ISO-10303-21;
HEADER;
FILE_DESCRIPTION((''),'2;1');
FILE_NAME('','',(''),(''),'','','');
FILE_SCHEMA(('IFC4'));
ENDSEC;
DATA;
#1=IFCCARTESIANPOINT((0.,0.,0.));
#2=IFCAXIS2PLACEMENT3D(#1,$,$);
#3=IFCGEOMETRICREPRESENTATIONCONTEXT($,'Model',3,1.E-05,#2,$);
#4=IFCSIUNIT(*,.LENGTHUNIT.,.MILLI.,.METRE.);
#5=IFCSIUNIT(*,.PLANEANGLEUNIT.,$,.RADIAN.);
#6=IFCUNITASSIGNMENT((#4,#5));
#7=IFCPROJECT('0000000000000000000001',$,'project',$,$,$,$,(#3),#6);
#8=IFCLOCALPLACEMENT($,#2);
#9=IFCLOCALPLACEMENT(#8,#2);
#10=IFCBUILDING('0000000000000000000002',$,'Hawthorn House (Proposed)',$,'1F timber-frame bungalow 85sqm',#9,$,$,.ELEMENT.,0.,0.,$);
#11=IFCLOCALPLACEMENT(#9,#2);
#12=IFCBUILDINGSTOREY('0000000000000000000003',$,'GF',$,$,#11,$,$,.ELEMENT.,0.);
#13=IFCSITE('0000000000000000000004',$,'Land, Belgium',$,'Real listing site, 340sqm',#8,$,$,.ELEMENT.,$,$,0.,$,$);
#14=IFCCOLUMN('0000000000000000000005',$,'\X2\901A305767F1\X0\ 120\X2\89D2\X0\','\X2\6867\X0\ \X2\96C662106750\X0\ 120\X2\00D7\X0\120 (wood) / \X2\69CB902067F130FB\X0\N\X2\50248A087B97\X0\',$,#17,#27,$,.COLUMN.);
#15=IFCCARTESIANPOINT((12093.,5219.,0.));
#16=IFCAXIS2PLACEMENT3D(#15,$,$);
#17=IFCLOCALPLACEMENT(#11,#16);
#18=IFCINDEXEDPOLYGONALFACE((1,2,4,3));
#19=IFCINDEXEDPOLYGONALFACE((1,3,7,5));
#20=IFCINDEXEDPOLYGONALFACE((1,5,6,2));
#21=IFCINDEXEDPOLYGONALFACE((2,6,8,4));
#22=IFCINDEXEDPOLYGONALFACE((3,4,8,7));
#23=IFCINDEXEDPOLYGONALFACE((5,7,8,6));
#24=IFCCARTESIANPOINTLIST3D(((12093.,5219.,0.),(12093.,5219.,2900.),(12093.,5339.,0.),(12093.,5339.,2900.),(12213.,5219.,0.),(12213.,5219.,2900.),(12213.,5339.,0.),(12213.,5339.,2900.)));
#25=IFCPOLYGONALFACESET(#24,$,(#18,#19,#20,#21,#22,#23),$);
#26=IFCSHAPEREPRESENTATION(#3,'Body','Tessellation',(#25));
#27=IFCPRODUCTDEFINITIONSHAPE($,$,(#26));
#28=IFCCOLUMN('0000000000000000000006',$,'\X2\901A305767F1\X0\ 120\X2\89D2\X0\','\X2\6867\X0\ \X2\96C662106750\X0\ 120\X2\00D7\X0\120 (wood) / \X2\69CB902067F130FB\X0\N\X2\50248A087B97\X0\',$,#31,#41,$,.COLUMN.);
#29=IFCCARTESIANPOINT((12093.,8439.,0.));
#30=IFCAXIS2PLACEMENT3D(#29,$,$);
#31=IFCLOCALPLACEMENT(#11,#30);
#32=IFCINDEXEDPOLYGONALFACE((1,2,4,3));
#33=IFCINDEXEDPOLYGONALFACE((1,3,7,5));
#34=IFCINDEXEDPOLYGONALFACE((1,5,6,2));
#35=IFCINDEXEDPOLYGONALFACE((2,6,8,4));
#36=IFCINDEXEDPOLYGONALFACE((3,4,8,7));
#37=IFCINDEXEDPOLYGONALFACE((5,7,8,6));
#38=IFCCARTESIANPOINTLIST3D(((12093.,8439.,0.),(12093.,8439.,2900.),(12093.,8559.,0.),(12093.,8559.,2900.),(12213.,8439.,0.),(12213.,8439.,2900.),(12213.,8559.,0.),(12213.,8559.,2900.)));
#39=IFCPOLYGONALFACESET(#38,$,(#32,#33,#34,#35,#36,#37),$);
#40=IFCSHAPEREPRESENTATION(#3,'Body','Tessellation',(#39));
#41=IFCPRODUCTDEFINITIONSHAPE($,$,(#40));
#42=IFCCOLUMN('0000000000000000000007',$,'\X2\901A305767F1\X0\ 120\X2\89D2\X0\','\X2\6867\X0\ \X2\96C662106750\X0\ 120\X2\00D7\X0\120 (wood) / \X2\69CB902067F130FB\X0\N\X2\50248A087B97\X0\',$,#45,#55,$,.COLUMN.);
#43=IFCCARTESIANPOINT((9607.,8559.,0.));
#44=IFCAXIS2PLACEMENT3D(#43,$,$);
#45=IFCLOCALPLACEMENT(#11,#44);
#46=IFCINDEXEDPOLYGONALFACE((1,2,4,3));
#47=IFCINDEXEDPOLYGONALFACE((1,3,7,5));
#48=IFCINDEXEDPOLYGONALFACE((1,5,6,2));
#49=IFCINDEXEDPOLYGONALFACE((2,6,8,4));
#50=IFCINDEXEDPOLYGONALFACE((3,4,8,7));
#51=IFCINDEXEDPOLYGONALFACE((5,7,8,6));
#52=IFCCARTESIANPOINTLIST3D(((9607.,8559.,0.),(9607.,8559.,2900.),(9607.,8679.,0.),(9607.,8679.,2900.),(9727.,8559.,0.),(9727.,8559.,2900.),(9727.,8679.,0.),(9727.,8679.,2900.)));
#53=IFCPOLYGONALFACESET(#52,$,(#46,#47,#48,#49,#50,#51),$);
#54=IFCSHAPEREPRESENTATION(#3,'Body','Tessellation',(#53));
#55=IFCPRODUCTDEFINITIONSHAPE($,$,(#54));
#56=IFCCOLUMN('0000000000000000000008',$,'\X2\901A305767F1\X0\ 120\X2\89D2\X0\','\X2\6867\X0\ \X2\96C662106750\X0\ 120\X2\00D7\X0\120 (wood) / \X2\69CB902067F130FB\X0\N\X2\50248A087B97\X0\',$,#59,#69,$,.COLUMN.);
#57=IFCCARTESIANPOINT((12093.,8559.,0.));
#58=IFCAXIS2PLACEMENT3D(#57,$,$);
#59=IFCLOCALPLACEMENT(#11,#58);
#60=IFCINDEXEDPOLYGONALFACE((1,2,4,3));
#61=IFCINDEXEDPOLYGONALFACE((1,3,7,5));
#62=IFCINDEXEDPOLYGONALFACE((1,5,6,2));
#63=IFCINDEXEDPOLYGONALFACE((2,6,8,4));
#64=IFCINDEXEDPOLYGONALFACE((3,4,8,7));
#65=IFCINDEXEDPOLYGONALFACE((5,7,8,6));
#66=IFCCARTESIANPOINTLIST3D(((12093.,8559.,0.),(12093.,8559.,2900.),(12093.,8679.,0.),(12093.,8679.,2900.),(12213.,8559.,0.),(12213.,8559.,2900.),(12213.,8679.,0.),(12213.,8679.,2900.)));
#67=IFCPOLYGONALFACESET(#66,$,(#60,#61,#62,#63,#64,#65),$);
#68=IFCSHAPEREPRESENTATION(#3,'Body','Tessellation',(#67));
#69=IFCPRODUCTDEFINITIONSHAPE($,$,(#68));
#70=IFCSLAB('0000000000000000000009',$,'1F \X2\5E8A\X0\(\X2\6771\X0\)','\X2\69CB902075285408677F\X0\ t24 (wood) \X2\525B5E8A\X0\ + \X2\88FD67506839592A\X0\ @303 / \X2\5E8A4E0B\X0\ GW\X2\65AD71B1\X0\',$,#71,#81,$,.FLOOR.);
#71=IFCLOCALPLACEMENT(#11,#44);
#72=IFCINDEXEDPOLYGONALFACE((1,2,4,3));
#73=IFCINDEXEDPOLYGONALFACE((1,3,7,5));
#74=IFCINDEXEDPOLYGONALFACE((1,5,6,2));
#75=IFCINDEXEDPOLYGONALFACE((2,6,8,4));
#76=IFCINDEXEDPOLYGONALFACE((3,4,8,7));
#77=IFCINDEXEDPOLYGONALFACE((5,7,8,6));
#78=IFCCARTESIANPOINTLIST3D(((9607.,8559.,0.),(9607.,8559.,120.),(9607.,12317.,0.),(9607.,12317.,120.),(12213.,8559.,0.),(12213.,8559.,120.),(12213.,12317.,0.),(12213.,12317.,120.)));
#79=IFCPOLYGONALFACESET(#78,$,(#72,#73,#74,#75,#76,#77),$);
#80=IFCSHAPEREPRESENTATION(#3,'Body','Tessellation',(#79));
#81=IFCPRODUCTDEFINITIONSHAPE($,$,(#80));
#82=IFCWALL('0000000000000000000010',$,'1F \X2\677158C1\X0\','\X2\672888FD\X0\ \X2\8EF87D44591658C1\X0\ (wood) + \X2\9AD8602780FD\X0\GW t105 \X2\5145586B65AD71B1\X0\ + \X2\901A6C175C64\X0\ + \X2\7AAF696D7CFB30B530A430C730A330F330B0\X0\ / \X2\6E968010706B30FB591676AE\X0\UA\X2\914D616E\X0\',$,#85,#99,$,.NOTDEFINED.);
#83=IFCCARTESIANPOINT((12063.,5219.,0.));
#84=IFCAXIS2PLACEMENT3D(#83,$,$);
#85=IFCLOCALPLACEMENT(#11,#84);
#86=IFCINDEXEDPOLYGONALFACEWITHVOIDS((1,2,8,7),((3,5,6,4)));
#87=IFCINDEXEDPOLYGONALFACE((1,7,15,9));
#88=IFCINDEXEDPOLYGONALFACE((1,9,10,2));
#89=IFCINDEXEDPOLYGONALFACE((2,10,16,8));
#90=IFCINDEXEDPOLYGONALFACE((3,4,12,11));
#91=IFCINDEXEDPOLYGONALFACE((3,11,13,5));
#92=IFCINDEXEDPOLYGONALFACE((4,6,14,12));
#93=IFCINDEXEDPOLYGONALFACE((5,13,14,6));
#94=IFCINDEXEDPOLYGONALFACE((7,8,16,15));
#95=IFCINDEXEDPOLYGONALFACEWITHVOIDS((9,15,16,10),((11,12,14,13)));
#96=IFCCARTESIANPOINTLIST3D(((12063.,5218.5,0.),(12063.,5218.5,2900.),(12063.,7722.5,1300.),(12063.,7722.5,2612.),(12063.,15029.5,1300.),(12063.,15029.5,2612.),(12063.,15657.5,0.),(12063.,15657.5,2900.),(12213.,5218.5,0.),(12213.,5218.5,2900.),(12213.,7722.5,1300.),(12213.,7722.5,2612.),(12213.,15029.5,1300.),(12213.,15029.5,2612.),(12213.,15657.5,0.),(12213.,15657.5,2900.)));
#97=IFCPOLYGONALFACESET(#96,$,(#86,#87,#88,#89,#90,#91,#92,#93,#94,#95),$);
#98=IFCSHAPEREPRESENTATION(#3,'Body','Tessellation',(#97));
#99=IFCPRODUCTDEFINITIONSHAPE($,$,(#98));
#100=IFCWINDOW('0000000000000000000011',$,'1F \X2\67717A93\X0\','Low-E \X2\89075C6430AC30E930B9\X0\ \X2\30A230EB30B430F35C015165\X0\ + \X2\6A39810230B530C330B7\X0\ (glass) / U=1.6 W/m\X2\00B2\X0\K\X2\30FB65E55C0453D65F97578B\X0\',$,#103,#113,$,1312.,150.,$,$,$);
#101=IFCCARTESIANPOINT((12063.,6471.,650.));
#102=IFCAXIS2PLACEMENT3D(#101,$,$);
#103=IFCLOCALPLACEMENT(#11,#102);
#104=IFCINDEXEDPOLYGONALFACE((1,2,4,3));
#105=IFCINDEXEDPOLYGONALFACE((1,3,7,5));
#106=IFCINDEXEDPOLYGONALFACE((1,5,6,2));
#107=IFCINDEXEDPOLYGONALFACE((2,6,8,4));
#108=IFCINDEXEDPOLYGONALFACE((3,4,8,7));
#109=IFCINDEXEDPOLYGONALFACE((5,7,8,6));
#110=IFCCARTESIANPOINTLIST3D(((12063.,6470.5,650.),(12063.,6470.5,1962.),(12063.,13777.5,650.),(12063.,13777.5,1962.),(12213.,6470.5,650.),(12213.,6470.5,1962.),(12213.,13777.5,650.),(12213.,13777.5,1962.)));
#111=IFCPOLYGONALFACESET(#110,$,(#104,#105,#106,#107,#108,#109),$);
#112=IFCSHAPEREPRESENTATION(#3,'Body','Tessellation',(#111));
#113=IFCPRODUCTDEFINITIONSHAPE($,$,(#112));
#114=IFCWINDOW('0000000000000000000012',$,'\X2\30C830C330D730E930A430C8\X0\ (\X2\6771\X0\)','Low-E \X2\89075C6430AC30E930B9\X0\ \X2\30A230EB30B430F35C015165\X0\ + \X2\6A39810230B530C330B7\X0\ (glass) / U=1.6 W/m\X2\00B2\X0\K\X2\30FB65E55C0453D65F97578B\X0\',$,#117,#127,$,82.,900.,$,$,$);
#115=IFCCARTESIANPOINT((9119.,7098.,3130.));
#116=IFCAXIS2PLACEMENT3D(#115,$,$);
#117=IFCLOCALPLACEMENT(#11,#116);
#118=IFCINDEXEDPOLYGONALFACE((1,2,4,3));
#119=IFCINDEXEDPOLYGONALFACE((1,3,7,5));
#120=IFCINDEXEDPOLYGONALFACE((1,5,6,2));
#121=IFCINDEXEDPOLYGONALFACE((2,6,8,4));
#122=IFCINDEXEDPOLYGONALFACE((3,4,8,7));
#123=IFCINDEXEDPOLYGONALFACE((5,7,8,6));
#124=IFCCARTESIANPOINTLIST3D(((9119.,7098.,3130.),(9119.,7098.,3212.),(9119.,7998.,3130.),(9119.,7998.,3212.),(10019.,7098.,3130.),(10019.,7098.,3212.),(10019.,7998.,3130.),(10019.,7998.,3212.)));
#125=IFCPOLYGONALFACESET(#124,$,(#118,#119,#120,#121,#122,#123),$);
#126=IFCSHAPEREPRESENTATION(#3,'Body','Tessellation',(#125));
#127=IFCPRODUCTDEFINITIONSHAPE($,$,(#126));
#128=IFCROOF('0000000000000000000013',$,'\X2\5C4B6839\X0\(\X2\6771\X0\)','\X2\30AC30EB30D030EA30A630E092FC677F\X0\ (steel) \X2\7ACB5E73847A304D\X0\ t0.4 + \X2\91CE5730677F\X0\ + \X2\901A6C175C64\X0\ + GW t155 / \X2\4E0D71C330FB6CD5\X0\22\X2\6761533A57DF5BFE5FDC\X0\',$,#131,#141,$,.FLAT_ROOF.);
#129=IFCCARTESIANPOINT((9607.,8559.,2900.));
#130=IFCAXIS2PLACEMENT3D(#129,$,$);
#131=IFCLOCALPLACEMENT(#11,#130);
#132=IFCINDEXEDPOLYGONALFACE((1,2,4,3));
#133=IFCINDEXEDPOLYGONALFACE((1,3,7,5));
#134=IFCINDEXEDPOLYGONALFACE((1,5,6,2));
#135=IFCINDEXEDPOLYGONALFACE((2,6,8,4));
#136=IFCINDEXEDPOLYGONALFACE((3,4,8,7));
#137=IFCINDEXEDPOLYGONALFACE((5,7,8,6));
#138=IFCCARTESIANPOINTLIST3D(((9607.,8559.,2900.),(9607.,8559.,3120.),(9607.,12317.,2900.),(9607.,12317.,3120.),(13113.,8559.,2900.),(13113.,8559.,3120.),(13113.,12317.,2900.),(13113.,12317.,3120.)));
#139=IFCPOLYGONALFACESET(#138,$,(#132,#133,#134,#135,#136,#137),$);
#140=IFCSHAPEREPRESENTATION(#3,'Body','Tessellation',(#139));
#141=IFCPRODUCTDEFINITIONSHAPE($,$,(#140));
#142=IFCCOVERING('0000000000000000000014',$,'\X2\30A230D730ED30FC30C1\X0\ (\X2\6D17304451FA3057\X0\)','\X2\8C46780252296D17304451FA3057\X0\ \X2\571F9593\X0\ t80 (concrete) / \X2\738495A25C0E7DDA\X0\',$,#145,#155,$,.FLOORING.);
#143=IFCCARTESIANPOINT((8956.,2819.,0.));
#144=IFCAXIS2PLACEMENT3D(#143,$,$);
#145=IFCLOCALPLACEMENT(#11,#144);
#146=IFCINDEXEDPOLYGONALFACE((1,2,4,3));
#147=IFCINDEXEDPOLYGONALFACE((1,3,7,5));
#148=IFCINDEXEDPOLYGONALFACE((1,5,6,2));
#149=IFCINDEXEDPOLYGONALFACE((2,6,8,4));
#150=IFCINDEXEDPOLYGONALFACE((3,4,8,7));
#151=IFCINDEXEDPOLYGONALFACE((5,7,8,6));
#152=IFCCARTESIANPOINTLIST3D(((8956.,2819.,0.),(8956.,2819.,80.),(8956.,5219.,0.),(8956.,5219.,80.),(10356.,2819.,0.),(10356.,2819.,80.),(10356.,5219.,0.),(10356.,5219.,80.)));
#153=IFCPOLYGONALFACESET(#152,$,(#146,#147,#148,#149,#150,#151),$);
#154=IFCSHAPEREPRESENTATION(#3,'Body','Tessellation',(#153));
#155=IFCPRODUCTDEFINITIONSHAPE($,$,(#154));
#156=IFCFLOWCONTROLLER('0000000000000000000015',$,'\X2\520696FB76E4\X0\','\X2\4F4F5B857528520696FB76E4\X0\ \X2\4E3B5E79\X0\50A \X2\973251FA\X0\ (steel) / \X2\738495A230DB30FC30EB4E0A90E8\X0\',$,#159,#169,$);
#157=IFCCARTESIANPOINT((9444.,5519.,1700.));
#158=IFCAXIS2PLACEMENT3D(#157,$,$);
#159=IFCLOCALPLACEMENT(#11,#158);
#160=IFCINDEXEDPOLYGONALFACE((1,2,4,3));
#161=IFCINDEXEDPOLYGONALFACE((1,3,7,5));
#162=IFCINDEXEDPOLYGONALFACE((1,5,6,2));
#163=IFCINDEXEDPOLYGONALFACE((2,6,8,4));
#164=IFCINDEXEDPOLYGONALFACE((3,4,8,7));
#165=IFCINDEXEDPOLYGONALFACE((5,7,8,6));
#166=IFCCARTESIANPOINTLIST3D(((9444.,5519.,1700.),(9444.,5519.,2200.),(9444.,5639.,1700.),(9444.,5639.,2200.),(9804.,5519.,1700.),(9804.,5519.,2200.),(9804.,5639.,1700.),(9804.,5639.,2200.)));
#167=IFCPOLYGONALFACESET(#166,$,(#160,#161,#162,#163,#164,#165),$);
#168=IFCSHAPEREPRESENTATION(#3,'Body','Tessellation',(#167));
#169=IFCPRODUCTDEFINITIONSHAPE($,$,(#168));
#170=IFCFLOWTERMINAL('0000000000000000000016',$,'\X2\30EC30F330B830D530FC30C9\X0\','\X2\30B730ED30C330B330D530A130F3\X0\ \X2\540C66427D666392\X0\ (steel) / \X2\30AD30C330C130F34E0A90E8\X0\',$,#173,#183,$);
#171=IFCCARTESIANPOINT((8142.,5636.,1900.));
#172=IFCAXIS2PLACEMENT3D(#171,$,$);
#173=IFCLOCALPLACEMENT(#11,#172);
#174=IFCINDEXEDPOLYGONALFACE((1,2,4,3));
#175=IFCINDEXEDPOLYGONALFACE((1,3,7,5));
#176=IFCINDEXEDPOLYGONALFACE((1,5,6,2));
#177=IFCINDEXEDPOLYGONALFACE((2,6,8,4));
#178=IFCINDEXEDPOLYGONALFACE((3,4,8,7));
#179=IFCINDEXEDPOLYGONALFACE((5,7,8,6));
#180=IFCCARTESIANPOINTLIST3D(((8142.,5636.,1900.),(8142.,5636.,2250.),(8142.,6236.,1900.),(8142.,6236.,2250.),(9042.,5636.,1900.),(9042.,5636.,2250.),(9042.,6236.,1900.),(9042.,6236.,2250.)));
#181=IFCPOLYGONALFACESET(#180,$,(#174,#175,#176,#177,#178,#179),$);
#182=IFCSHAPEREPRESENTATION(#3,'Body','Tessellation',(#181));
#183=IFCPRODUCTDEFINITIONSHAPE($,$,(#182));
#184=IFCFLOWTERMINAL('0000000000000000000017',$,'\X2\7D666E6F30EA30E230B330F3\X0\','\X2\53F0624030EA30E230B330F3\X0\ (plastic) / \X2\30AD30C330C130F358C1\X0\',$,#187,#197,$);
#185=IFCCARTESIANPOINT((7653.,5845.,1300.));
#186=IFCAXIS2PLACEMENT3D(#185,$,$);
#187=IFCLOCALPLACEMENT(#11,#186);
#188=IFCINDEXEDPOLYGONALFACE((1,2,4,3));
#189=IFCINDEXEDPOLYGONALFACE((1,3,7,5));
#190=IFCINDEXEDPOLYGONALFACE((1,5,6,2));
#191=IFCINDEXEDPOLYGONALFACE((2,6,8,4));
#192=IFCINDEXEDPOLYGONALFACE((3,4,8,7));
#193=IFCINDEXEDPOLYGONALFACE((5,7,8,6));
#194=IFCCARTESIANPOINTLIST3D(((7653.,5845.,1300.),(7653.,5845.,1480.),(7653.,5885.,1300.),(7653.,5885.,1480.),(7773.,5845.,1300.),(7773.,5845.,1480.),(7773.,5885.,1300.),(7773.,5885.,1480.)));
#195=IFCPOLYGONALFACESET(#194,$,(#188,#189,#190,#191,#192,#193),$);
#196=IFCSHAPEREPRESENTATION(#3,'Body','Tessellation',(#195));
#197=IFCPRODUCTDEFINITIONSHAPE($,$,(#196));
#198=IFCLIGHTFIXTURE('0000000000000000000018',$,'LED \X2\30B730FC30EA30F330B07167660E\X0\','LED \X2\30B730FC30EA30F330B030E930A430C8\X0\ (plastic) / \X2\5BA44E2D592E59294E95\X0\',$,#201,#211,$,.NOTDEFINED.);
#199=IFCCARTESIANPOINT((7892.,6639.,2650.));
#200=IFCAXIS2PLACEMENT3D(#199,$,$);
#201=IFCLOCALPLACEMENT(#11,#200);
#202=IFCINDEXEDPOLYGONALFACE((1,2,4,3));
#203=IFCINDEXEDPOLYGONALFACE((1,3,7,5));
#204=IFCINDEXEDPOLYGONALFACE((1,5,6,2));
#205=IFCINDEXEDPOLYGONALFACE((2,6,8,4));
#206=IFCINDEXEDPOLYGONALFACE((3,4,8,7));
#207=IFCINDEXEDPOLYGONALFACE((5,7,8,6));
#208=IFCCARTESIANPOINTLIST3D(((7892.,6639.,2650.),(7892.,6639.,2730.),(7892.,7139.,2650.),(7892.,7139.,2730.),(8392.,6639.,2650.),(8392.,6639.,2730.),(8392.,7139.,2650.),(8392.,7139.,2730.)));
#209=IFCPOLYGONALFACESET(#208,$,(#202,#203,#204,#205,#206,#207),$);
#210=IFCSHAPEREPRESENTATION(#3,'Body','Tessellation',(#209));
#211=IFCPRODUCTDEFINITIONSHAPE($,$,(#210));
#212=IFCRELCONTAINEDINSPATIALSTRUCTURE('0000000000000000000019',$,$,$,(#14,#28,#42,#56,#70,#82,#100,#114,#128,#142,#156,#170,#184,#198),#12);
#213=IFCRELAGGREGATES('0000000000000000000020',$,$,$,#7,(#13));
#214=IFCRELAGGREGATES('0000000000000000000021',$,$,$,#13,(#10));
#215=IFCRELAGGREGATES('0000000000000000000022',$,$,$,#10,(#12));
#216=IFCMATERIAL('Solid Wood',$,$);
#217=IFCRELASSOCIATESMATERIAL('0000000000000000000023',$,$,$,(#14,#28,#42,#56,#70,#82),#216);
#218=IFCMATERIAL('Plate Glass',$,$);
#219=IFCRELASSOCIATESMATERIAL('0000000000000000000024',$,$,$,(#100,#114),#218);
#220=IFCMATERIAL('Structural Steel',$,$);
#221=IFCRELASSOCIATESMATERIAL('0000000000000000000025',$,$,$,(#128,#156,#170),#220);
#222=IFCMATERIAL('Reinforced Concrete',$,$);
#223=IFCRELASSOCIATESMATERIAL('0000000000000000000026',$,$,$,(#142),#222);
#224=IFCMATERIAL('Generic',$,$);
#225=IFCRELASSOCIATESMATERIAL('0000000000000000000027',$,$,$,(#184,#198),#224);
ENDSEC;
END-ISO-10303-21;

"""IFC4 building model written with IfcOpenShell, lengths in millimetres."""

from ifc_helpers import new_model, si_unit, frame, frame_2d, origin, place, context, project, spatial, rectangle, extrude, material, element, fill, save


model = new_model("IFC4")

# Units and contexts
model_context = context("Model", 3, precision=1e-05, world=origin())
ifc_project = project(units=[si_unit("LENGTHUNIT", "METRE", prefix="MILLI"), si_unit("PLANEANGLEUNIT", "RADIAN")], contexts=[model_context])

# Site, building, storey
site_placement = place(None, origin())
site = spatial("IfcSite", under=ifc_project, at=site_placement, Name="Land, Belgium", ObjectType="Real listing site, 340sqm", CompositionType="ELEMENT", RefElevation=0.0)
building_placement = place(site_placement, origin())
building = spatial("IfcBuilding", under=site, at=building_placement, Name="Hawthorn House (Proposed)", ObjectType="1F timber-frame bungalow 85sqm", CompositionType="ELEMENT", ElevationOfRefHeight=0.0, ElevationOfTerrain=0.0)
storey_placement = place(building_placement, origin())
storey = spatial("IfcBuildingStorey", under=building, at=storey_placement, Name="GF", CompositionType="ELEMENT", Elevation=0.0)

# Columns
ifc_material_1 = material(Name="Solid Wood")
column_1_placement = place(storey_placement, frame((12093.0, 5219.0, 0.0)))
element("IfcColumn", 1, at=column_1_placement, inside=storey, material=ifc_material_1, Name="通し柱 120角", Description="桧 集成材 120×120 (wood) / 構造柱・N値計算", PredefinedType="COLUMN", context=model_context, shape_type="SweptSolid", body=[
    extrude(rectangle(XDim=120.0, YDim=120.0, at=frame_2d((60.0, 60.0))), frame((12093.0, 5219.0, 0.0)), (0.0, 0.0, 1.0), 2900.0),
])
column_2_placement = place(storey_placement, frame((12093.0, 8439.0, 0.0)))
element("IfcColumn", 2, at=column_2_placement, inside=storey, material=ifc_material_1, Name="通し柱 120角", Description="桧 集成材 120×120 (wood) / 構造柱・N値計算", PredefinedType="COLUMN", context=model_context, shape_type="SweptSolid", body=[
    extrude(rectangle(XDim=120.0, YDim=120.0, at=frame_2d((60.0, 60.0))), frame((12093.0, 8439.0, 0.0)), (0.0, 0.0, 1.0), 2900.0),
])
column_3_placement = place(storey_placement, frame((9607.0, 8559.0, 0.0)))
element("IfcColumn", 3, at=column_3_placement, inside=storey, material=ifc_material_1, Name="通し柱 120角", Description="桧 集成材 120×120 (wood) / 構造柱・N値計算", PredefinedType="COLUMN", context=model_context, shape_type="SweptSolid", body=[
    extrude(rectangle(XDim=120.0, YDim=120.0, at=frame_2d((60.0, 60.0))), frame((9607.0, 8559.0, 0.0)), (0.0, 0.0, 1.0), 2900.0),
])
column_4_placement = place(storey_placement, frame((12093.0, 8559.0, 0.0)))
element("IfcColumn", 4, at=column_4_placement, inside=storey, material=ifc_material_1, Name="通し柱 120角", Description="桧 集成材 120×120 (wood) / 構造柱・N値計算", PredefinedType="COLUMN", context=model_context, shape_type="SweptSolid", body=[
    extrude(rectangle(XDim=120.0, YDim=120.0, at=frame_2d((60.0, 60.0))), frame((12093.0, 8559.0, 0.0)), (0.0, 0.0, 1.0), 2900.0),
])

# Slab
slab_placement = place(storey_placement, frame((9607.0, 8559.0, 0.0)))
element("IfcSlab", 5, at=slab_placement, inside=storey, material=ifc_material_1, Name="1F 床(東)", Description="構造用合板 t24 (wood) 剛床 + 製材根太 @303 / 床下 GW断熱", PredefinedType="FLOOR", context=model_context, shape_type="SweptSolid", body=[
    extrude(rectangle(XDim=2606.0, YDim=3758.0, at=frame_2d((1303.0, 1879.0))), frame((9607.0, 8559.0, 0.0)), (0.0, 0.0, 1.0), 120.0),
])

# Wall, opening, window
wall_1_placement = place(storey_placement, frame((12063.0, 5219.0, 0.0)))
wall_1 = element("IfcWall", 6, at=wall_1_placement, inside=storey, material=ifc_material_1, Name="1F 東壁", Description="木製 軸組外壁 (wood) + 高性能GW t105 充填断熱 + 通気層 + 窯業系サイディング / 準耐火・外皮UA配慮", PredefinedType="NOTDEFINED", context=model_context, shape_type="SweptSolid", body=[
    extrude(rectangle(XDim=150.0, YDim=10439.0, at=frame_2d((75.0, 5219.0))), frame((12063.0, 5219.0, 0.0)), (0.0, 0.0, 1.0), 2900.0),
])
opening_placement = place(storey_placement, frame((12063.0, 6471.0, 650.0)))
opening = element("IfcOpeningElement", 7, at=opening_placement, cuts=wall_1, PredefinedType="NOTDEFINED", context=model_context, shape_type="SweptSolid", body=[
    extrude(rectangle(XDim=150.0, YDim=7307.0, at=frame_2d((75.0, 3653.0))), frame((12063.0, 6471.0, 650.0)), (0.0, 0.0, 1.0), 1312.0),
])
ifc_material_2 = material(Name="Plate Glass")
window_1_placement = place(storey_placement, frame((12063.0, 6471.0, 650.0)))
window_1 = element("IfcWindow", 8, at=window_1_placement, inside=storey, material=ifc_material_2, Name="1F 東窓", Description="Low-E 複層ガラス アルゴン封入 + 樹脂サッシ (glass) / U=1.6 W/m²K・日射取得型", OverallHeight=1312.0, OverallWidth=150.0, context=model_context, shape_type="SweptSolid", body=[
    extrude(rectangle(XDim=150.0, YDim=7307.0, at=frame_2d((75.0, 3653.0))), frame((12063.0, 6471.0, 650.0)), (0.0, 0.0, 1.0), 1312.0),
])
fill(opening, window_1)

# Window
window_2_placement = place(storey_placement, frame((9119.0, 7098.0, 3130.0)))
element("IfcWindow", 9, at=window_2_placement, inside=storey, material=ifc_material_2, Name="トップライト (東)", Description="Low-E 複層ガラス アルゴン封入 + 樹脂サッシ (glass) / U=1.6 W/m²K・日射取得型", OverallHeight=82.0, OverallWidth=900.0, context=model_context, shape_type="SweptSolid", body=[
    extrude(rectangle(XDim=900.0, YDim=900.0, at=frame_2d((450.0, 450.0))), frame((9119.0, 7098.0, 3130.0)), (0.0, 0.0, 1.0), 82.0),
])

# Roof
ifc_material_3 = material(Name="Structural Steel")
roof_placement = place(storey_placement, frame((9607.0, 8559.0, 2900.0)))
element("IfcRoof", 10, at=roof_placement, inside=storey, material=ifc_material_3, Name="屋根(東)", Description="ガルバリウム鋼板 (steel) 立平葺き t0.4 + 野地板 + 通気層 + GW t155 / 不燃・法22条区域対応", PredefinedType="FLAT_ROOF", context=model_context, shape_type="SweptSolid", body=[
    extrude(rectangle(XDim=3506.0, YDim=3758.0, at=frame_2d((1753.0, 1879.0))), frame((9607.0, 8559.0, 2900.0)), (0.0, 0.0, 1.0), 220.0),
])

# Covering
ifc_material_4 = material(Name="Reinforced Concrete")
covering_placement = place(storey_placement, frame((8956.0, 2819.0, 0.0)))
element("IfcCovering", 11, at=covering_placement, inside=storey, material=ifc_material_4, Name="アプローチ (洗い出し)", Description="豆砂利洗い出し 土間 t80 (concrete) / 玄関導線", PredefinedType="FLOORING", context=model_context, shape_type="SweptSolid", body=[
    extrude(rectangle(XDim=1400.0, YDim=2400.0, at=frame_2d((700.0, 1200.0))), frame((8956.0, 2819.0, 0.0)), (0.0, 0.0, 1.0), 80.0),
])

# Flow controller
flow_controller_placement = place(storey_placement, frame((9444.0, 5519.0, 1700.0)))
element("IfcFlowController", 12, at=flow_controller_placement, inside=storey, material=ifc_material_3, Name="分電盤", Description="住宅用分電盤 主幹50A 露出 (steel) / 玄関ホール上部", context=model_context, shape_type="SweptSolid", body=[
    extrude(rectangle(XDim=360.0, YDim=120.0, at=frame_2d((180.0, 60.0))), frame((9444.0, 5519.0, 1700.0)), (0.0, 0.0, 1.0), 500.0),
])

# Flow terminals
flow_terminal_1_placement = place(storey_placement, frame((8142.0, 5636.0, 1900.0)))
element("IfcFlowTerminal", 13, at=flow_terminal_1_placement, inside=storey, material=ifc_material_3, Name="レンジフード", Description="シロッコファン 同時給排 (steel) / キッチン上部", context=model_context, shape_type="SweptSolid", body=[
    extrude(rectangle(XDim=900.0, YDim=600.0, at=frame_2d((450.0, 300.0))), frame((8142.0, 5636.0, 1900.0)), (0.0, 0.0, 1.0), 350.0),
])
ifc_material_5 = material(Name="Generic")
flow_terminal_2_placement = place(storey_placement, frame((7653.0, 5845.0, 1300.0)))
element("IfcFlowTerminal", 14, at=flow_terminal_2_placement, inside=storey, material=ifc_material_5, Name="給湯リモコン", Description="台所リモコン (plastic) / キッチン壁", context=model_context, shape_type="SweptSolid", body=[
    extrude(rectangle(XDim=120.0, YDim=40.0, at=frame_2d((60.0, 20.0))), frame((7653.0, 5845.0, 1300.0)), (0.0, 0.0, 1.0), 180.0),
])

# Light fixture
light_fixture_placement = place(storey_placement, frame((7892.0, 6639.0, 2650.0)))
element("IfcLightFixture", 15, at=light_fixture_placement, inside=storey, material=ifc_material_5, Name="LED シーリング照明", Description="LED シーリングライト (plastic) / 室中央天井", PredefinedType="NOTDEFINED", context=model_context, shape_type="SweptSolid", body=[
    extrude(rectangle(XDim=500.0, YDim=500.0, at=frame_2d((250.0, 250.0))), frame((7892.0, 6639.0, 2650.0)), (0.0, 0.0, 1.0), 80.0),
])

save(model, "model.ifc")
